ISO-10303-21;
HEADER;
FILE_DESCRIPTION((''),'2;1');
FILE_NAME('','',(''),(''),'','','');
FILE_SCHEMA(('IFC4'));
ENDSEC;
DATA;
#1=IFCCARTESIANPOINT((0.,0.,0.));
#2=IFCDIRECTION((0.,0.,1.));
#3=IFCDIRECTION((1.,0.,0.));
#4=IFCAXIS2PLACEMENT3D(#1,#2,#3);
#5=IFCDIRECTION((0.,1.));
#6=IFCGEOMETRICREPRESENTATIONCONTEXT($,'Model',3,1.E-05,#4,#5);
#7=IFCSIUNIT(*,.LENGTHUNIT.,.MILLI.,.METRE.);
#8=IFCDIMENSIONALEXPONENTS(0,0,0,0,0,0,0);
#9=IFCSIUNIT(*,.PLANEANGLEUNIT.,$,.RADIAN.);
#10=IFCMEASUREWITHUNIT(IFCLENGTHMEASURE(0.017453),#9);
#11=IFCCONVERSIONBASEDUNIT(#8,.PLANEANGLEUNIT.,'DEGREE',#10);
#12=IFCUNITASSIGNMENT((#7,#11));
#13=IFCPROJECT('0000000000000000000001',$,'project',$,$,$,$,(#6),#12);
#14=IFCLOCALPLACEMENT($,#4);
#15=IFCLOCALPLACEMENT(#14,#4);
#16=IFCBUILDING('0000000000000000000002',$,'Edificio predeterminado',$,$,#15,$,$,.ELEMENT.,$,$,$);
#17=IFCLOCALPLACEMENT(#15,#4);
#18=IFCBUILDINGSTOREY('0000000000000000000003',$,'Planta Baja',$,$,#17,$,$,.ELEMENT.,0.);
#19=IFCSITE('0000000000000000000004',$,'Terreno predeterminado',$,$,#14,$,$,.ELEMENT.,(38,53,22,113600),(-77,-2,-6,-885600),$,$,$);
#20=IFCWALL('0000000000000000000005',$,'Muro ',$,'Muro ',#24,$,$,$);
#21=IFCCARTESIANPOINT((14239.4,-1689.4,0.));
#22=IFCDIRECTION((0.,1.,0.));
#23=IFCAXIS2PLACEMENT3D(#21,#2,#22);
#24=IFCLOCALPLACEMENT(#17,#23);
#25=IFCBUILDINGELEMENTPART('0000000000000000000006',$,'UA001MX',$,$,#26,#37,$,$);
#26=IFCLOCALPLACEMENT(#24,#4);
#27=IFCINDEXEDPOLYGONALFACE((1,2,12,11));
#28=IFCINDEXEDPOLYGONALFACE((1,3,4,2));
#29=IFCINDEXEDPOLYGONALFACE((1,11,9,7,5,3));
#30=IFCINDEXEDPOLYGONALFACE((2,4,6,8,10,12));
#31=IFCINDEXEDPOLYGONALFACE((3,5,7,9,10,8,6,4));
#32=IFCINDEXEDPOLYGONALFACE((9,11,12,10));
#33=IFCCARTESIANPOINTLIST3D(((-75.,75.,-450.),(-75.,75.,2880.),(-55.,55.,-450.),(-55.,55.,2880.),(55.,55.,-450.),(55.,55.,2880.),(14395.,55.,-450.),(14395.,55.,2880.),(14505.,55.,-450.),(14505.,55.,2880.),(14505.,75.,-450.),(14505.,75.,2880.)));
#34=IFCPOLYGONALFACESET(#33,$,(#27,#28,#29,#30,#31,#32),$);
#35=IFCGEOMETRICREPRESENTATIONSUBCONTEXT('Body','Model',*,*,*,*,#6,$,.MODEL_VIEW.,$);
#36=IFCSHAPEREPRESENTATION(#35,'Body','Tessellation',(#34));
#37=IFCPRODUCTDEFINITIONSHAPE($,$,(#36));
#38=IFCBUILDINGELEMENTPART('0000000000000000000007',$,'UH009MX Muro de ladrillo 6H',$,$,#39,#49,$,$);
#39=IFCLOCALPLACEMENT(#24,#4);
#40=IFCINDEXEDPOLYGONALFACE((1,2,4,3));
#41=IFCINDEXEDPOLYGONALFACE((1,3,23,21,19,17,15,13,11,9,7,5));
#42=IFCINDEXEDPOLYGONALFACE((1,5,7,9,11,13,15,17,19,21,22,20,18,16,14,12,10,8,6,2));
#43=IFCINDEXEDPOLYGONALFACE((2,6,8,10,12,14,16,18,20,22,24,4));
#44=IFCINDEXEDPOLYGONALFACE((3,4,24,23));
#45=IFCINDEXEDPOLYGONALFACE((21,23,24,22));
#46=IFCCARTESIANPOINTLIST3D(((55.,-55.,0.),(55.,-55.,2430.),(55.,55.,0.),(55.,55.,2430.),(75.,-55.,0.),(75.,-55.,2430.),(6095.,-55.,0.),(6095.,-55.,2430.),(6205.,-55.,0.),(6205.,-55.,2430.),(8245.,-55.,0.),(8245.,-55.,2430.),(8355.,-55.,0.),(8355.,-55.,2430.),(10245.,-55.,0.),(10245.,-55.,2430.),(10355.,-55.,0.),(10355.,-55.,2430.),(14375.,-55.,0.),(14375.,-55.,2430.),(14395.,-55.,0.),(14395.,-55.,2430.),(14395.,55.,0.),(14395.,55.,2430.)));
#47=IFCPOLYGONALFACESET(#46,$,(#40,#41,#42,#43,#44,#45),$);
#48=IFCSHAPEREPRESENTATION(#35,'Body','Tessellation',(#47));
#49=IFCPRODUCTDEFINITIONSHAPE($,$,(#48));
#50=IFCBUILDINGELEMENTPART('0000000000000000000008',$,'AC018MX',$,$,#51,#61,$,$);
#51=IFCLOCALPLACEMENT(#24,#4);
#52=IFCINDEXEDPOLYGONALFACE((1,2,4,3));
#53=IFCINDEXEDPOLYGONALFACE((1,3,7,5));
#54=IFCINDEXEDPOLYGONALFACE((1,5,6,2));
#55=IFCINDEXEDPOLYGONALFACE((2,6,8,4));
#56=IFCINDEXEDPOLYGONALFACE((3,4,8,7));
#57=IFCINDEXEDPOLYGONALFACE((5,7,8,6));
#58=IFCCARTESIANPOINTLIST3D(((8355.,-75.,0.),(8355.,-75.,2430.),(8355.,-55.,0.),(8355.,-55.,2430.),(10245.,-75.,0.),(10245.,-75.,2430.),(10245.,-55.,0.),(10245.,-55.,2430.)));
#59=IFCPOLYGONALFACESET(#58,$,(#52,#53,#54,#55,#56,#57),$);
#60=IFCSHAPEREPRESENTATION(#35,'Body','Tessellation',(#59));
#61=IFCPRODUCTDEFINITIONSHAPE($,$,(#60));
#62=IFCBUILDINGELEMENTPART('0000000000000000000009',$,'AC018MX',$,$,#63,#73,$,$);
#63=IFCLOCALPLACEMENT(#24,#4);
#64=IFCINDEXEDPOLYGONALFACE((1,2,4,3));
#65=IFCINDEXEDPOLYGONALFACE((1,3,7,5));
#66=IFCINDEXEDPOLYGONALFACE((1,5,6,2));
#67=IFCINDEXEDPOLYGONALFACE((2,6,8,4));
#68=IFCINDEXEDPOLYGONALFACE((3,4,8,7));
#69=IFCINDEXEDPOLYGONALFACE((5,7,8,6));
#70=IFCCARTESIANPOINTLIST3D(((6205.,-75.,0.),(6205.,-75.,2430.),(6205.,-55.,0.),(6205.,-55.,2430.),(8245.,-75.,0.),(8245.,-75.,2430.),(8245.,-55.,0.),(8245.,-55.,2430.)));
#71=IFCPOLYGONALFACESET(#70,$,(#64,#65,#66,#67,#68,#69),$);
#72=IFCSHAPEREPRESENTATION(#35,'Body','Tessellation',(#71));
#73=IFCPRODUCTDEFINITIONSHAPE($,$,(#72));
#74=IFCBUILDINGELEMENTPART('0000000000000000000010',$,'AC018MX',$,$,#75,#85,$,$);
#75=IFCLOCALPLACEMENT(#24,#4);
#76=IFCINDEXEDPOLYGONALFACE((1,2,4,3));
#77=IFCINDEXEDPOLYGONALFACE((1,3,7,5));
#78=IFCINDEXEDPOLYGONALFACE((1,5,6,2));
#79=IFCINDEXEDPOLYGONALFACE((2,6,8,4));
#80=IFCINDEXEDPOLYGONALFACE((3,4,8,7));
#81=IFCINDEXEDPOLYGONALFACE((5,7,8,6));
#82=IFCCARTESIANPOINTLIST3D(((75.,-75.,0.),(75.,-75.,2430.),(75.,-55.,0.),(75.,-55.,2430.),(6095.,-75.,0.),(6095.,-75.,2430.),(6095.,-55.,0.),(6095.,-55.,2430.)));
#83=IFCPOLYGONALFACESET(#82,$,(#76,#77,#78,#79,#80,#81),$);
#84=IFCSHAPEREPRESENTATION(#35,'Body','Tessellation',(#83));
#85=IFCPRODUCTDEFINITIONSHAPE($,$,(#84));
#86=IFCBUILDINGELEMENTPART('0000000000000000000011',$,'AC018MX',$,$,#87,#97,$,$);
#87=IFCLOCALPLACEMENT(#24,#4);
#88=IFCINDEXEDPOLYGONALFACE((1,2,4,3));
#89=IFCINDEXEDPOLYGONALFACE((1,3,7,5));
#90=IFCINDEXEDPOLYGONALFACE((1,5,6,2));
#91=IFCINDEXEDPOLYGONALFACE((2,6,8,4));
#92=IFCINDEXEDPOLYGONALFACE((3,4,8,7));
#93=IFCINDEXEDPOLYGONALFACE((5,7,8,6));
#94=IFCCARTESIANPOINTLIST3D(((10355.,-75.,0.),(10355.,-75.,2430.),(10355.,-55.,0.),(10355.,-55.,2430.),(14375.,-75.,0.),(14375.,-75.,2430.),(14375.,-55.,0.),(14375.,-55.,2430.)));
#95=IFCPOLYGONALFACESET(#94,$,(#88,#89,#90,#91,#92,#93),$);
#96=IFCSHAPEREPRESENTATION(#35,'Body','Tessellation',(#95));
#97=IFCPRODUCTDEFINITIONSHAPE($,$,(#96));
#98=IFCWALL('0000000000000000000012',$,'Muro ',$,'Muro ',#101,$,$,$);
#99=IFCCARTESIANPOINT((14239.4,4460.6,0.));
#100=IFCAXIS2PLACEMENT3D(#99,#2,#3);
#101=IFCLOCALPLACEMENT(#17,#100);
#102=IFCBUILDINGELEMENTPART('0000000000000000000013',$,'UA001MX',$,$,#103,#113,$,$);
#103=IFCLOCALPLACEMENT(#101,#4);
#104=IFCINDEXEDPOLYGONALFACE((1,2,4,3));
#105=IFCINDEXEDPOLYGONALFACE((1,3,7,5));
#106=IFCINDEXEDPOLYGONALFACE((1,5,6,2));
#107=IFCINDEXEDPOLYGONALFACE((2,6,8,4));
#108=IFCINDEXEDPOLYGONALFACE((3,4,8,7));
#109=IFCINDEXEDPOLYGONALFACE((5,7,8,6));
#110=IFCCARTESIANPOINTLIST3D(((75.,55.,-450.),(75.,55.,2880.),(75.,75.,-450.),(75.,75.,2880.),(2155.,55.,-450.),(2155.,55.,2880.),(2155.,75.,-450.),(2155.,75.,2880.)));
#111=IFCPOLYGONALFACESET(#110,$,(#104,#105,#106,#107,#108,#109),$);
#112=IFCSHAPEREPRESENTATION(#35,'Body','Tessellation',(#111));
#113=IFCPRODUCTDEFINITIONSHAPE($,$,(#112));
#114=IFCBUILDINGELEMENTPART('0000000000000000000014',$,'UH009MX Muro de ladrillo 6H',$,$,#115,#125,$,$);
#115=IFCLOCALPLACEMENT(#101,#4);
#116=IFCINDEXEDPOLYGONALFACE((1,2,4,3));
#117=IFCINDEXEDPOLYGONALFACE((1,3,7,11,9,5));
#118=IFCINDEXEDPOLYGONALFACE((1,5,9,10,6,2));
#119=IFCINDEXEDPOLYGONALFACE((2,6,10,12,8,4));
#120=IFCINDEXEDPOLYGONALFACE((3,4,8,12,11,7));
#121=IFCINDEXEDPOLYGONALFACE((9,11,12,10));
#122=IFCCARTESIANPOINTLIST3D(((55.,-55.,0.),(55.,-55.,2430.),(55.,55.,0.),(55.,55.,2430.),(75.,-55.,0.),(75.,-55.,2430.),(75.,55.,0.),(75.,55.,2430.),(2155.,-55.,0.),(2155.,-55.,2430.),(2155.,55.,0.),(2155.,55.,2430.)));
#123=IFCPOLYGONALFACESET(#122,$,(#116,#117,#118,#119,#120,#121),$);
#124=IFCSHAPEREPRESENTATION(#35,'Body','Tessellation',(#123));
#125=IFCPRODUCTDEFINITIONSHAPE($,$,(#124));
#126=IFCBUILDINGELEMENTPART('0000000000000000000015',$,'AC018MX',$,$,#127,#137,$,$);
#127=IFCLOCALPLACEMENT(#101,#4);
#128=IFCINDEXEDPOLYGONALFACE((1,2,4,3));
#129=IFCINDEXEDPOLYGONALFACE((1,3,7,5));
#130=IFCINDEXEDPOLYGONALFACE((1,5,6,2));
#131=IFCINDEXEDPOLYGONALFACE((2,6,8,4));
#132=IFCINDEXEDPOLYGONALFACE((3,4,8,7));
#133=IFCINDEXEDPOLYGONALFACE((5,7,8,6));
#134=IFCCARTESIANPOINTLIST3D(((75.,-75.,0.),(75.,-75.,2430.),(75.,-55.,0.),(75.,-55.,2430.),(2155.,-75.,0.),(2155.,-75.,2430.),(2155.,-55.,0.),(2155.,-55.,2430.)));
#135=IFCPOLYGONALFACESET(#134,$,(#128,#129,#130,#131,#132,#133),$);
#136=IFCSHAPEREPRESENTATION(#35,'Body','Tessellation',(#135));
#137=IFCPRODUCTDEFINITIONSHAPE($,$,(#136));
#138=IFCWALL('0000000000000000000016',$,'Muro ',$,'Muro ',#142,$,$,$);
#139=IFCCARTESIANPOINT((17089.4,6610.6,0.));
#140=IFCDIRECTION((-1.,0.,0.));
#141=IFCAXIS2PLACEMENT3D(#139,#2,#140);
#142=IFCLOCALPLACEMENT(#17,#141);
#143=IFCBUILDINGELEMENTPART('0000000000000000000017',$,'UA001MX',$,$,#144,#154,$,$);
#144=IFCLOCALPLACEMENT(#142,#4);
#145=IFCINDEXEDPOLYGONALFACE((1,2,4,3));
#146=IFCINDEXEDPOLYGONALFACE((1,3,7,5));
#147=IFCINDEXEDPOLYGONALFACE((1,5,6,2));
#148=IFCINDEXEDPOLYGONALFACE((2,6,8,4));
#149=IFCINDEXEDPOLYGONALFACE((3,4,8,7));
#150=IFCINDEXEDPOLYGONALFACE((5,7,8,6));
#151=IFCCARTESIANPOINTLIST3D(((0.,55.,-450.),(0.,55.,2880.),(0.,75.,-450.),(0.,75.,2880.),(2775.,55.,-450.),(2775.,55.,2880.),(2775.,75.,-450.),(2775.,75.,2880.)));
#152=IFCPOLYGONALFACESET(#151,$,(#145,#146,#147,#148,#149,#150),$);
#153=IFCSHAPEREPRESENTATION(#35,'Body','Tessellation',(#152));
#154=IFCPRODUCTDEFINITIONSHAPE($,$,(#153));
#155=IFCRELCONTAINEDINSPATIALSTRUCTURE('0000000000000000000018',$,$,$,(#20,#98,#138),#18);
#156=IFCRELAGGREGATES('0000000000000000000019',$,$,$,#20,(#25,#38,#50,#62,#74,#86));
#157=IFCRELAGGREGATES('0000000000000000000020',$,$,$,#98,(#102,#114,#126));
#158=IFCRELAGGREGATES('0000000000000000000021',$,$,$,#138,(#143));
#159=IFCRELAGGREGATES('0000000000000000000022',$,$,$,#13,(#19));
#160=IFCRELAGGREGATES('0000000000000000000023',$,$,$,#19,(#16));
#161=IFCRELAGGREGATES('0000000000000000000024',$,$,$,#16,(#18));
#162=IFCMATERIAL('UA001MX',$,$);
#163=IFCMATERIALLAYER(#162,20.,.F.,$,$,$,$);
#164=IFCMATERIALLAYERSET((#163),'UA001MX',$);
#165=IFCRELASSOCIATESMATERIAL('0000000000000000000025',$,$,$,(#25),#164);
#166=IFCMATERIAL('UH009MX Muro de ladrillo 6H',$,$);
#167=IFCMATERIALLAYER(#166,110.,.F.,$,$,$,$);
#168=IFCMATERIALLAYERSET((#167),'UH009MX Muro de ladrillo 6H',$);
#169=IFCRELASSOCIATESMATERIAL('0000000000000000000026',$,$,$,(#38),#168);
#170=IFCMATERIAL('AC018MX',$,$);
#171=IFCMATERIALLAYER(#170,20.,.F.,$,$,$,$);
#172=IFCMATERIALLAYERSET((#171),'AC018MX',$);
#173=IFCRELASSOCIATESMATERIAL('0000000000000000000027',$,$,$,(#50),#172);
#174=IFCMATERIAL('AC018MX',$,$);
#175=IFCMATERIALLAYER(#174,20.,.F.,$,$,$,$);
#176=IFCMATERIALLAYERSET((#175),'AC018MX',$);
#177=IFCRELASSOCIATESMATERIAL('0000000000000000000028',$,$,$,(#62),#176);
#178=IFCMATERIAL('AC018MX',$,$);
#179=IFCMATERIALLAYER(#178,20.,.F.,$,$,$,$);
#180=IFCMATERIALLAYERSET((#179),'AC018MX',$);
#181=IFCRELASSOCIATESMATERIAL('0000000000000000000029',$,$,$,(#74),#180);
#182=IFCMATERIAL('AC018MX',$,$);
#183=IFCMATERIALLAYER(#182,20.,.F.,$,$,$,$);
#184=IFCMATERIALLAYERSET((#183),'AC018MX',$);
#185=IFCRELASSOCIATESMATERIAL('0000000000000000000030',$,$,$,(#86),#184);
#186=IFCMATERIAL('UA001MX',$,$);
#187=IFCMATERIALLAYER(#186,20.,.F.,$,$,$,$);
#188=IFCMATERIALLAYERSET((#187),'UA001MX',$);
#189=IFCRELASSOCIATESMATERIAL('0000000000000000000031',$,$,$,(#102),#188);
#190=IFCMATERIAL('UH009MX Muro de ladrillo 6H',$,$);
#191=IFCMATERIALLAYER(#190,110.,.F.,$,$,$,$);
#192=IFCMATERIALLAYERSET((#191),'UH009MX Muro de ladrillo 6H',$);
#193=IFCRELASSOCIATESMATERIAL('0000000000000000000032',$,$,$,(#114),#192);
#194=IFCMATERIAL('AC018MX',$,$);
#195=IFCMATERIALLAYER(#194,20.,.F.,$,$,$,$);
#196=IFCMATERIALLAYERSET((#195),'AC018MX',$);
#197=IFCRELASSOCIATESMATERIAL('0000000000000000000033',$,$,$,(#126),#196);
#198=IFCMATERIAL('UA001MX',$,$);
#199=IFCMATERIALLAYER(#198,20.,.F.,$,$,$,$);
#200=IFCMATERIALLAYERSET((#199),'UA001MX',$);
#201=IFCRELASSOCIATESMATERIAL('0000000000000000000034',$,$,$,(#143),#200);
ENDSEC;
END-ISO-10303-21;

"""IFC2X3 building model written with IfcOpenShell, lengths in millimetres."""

from ifc_helpers import new_model, entity, si_unit, converted_unit, direction, frame, origin_with_axes, place, context, subcontext, project, spatial, polyline, outline, extrude, material, layer, layer_set, layer_usage, element, aggregate, save


model = new_model("IFC2X3")

# Units and contexts
model_context = context("Model", 3, precision=1e-05, world=origin_with_axes(), true_north=direction((0.0, 1.0)))
body_context = subcontext(model_context, "Body", "Model", "MODEL_VIEW")
ifc_project = project(units=[si_unit("LENGTHUNIT", "METRE", prefix="MILLI"), converted_unit("PLANEANGLEUNIT", "DEGREE", entity("IfcLengthMeasure", 0.017453), si_unit("PLANEANGLEUNIT", "RADIAN"), dimensions=[0, 0, 0, 0, 0, 0, 0])], contexts=[model_context])

# Site, building, storey
site_placement = place(None, origin_with_axes())
site = spatial("IfcSite", under=ifc_project, at=site_placement, Name="Terreno predeterminado", CompositionType="ELEMENT", RefLatitude=(38, 53, 22, 113600), RefLongitude=(-77, -2, -6, -885600))
building_placement = place(site_placement, origin_with_axes())
building = spatial("IfcBuilding", under=site, at=building_placement, Name="Edificio predeterminado", CompositionType="ELEMENT")
storey_placement = place(building_placement, origin_with_axes())
storey = spatial("IfcBuildingStorey", under=building, at=storey_placement, Name="Planta Baja", CompositionType="ELEMENT", Elevation=0.0)

# Walls, building element parts
wall_1_placement = place(storey_placement, frame((14239.4, -1689.4, 0.0), z_axis=(0.0, 0.0, 1.0), x_axis=(0.0, 1.0, 0.0)))
wall_1 = element("IfcWall", 1, at=wall_1_placement, inside=storey, Name="Muro ", ObjectType="Muro ")
ifc_material_1 = material(Name="UA001MX")
ifc_layer_1 = layer(ifc_material_1, 20.0, ventilated=False)
ifc_layer_set_1 = layer_set([ifc_layer_1], Name="UA001MX")
ifc_layer_usage_1 = layer_usage(ifc_layer_set_1, "AXIS2", "NEGATIVE", -75.0)
building_element_part_1_placement = place(wall_1_placement, origin_with_axes())
building_element_part_1 = element("IfcBuildingElementPart", 2, at=building_element_part_1_placement, material=ifc_layer_usage_1, Name="UA001MX", context=body_context, shape_type="SweptSolid", body=[
    extrude(outline(polyline([(14505.0, 75.0), (14505.0, 55.0), (14395.0, 55.0), (55.0, 55.0), (-55.0, 55.0), (-75.0, 75.0), (14505.0, 75.0)])), frame((0.0, 0.0, -450.0), z_axis=(0.0, 0.0, 1.0), x_axis=(1.0, 0.0, 0.0)), (0.0, 0.0, 1.0), 3330.0),
])
ifc_material_2 = material(Name="UH009MX Muro de ladrillo 6H")
ifc_layer_2 = layer(ifc_material_2, 110.0, ventilated=False)
ifc_layer_set_2 = layer_set([ifc_layer_2], Name="UH009MX Muro de ladrillo 6H")
ifc_layer_usage_2 = layer_usage(ifc_layer_set_2, "AXIS2", "NEGATIVE", -55.0)
building_element_part_2_placement = place(wall_1_placement, origin_with_axes())
building_element_part_2 = element("IfcBuildingElementPart", 3, at=building_element_part_2_placement, material=ifc_layer_usage_2, Name="UH009MX Muro de ladrillo 6H", context=body_context, shape_type="SweptSolid", body=[
    extrude(outline(polyline([(14395.0, 55.0), (14395.0, -55.0), (14375.0, -55.0), (10355.0, -55.0), (10245.0, -55.0), (8355.0, -55.0), (8245.0, -55.0), (6205.0, -55.0), (6095.0, -55.0), (75.0, -55.0), (55.0, -55.0), (55.0, 55.0), (14395.0, 55.0)])), origin_with_axes(), (0.0, 0.0, 1.0), 2430.0),
])
ifc_material_3 = material(Name="AC018MX")
ifc_layer_3 = layer(ifc_material_3, 20.0, ventilated=False)
ifc_layer_set_3 = layer_set([ifc_layer_3], Name="AC018MX")
ifc_layer_usage_3 = layer_usage(ifc_layer_set_3, "AXIS2", "NEGATIVE", 55.0)
building_element_part_3_placement = place(wall_1_placement, origin_with_axes())
building_element_part_3 = element("IfcBuildingElementPart", 4, at=building_element_part_3_placement, material=ifc_layer_usage_3, Name="AC018MX", context=body_context, shape_type="SweptSolid", body=[
    extrude(outline(polyline([(8355.0, -55.0), (10245.0, -55.0), (10245.0, -75.0), (8355.0, -75.0), (8355.0, -55.0)])), origin_with_axes(), (0.0, 0.0, 1.0), 2430.0),
])
ifc_material_4 = material(Name="AC018MX")
ifc_layer_4 = layer(ifc_material_4, 20.0, ventilated=False)
ifc_layer_set_4 = layer_set([ifc_layer_4], Name="AC018MX")
ifc_layer_usage_4 = layer_usage(ifc_layer_set_4, "AXIS2", "NEGATIVE", 55.0)
building_element_part_4_placement = place(wall_1_placement, origin_with_axes())
building_element_part_4 = element("IfcBuildingElementPart", 5, at=building_element_part_4_placement, material=ifc_layer_usage_4, Name="AC018MX", context=body_context, shape_type="SweptSolid", body=[
    extrude(outline(polyline([(8245.0, -55.0), (8245.0, -75.0), (6205.0, -75.0), (6205.0, -55.0), (8245.0, -55.0)])), origin_with_axes(), (0.0, 0.0, 1.0), 2430.0),
])
ifc_material_5 = material(Name="AC018MX")
ifc_layer_5 = layer(ifc_material_5, 20.0, ventilated=False)
ifc_layer_set_5 = layer_set([ifc_layer_5], Name="AC018MX")
ifc_layer_usage_5 = layer_usage(ifc_layer_set_5, "AXIS2", "NEGATIVE", 55.0)
building_element_part_5_placement = place(wall_1_placement, origin_with_axes())
building_element_part_5 = element("IfcBuildingElementPart", 6, at=building_element_part_5_placement, material=ifc_layer_usage_5, Name="AC018MX", context=body_context, shape_type="SweptSolid", body=[
    extrude(outline(polyline([(6095.0, -55.0), (6095.0, -75.0), (75.0, -75.0), (75.0, -55.0), (6095.0, -55.0)])), origin_with_axes(), (0.0, 0.0, 1.0), 2430.0),
])
ifc_material_6 = material(Name="AC018MX")
ifc_layer_6 = layer(ifc_material_6, 20.0, ventilated=False)
ifc_layer_set_6 = layer_set([ifc_layer_6], Name="AC018MX")
ifc_layer_usage_6 = layer_usage(ifc_layer_set_6, "AXIS2", "NEGATIVE", 55.0)
building_element_part_6_placement = place(wall_1_placement, origin_with_axes())
building_element_part_6 = element("IfcBuildingElementPart", 7, at=building_element_part_6_placement, material=ifc_layer_usage_6, Name="AC018MX", context=body_context, shape_type="SweptSolid", body=[
    extrude(outline(polyline([(14375.0, -55.0), (14375.0, -75.0), (10355.0, -75.0), (10355.0, -55.0), (14375.0, -55.0)])), origin_with_axes(), (0.0, 0.0, 1.0), 2430.0),
])
aggregate(wall_1, [building_element_part_1, building_element_part_2, building_element_part_3, building_element_part_4, building_element_part_5, building_element_part_6])
wall_2_placement = place(storey_placement, frame((14239.4, 4460.6, 0.0), z_axis=(0.0, 0.0, 1.0), x_axis=(1.0, 0.0, 0.0)))
wall_2 = element("IfcWall", 8, at=wall_2_placement, inside=storey, Name="Muro ", ObjectType="Muro ")
ifc_material_7 = material(Name="UA001MX")
ifc_layer_7 = layer(ifc_material_7, 20.0, ventilated=False)
ifc_layer_set_7 = layer_set([ifc_layer_7], Name="UA001MX")
ifc_layer_usage_7 = layer_usage(ifc_layer_set_7, "AXIS2", "NEGATIVE", -75.0)
building_element_part_7_placement = place(wall_2_placement, origin_with_axes())
building_element_part_7 = element("IfcBuildingElementPart", 9, at=building_element_part_7_placement, material=ifc_layer_usage_7, Name="UA001MX", context=body_context, shape_type="SweptSolid", body=[
    extrude(outline(polyline([(2155.0, 75.0), (2155.0, 55.0), (75.0, 55.0), (75.0, 75.0), (2155.0, 75.0)])), frame((0.0, 0.0, -450.0), z_axis=(0.0, 0.0, 1.0), x_axis=(1.0, 0.0, 0.0)), (0.0, 0.0, 1.0), 3330.0),
])
ifc_material_8 = material(Name="UH009MX Muro de ladrillo 6H")
ifc_layer_8 = layer(ifc_material_8, 110.0, ventilated=False)
ifc_layer_set_8 = layer_set([ifc_layer_8], Name="UH009MX Muro de ladrillo 6H")
ifc_layer_usage_8 = layer_usage(ifc_layer_set_8, "AXIS2", "NEGATIVE", -55.0)
building_element_part_8_placement = place(wall_2_placement, origin_with_axes())
building_element_part_8 = element("IfcBuildingElementPart", 10, at=building_element_part_8_placement, material=ifc_layer_usage_8, Name="UH009MX Muro de ladrillo 6H", context=body_context, shape_type="SweptSolid", body=[
    extrude(outline(polyline([(2155.0, 55.0), (2155.0, -55.0), (75.0, -55.0), (55.0, -55.0), (55.0, 55.0), (75.0, 55.0), (2155.0, 55.0)])), origin_with_axes(), (0.0, 0.0, 1.0), 2430.0),
])
ifc_material_9 = material(Name="AC018MX")
ifc_layer_9 = layer(ifc_material_9, 20.0, ventilated=False)
ifc_layer_set_9 = layer_set([ifc_layer_9], Name="AC018MX")
ifc_layer_usage_9 = layer_usage(ifc_layer_set_9, "AXIS2", "NEGATIVE", 55.0)
building_element_part_9_placement = place(wall_2_placement, origin_with_axes())
building_element_part_9 = element("IfcBuildingElementPart", 11, at=building_element_part_9_placement, material=ifc_layer_usage_9, Name="AC018MX", context=body_context, shape_type="SweptSolid", body=[
    extrude(outline(polyline([(2155.0, -55.0), (2155.0, -75.0), (75.0, -75.0), (75.0, -55.0), (2155.0, -55.0)])), origin_with_axes(), (0.0, 0.0, 1.0), 2430.0),
])
aggregate(wall_2, [building_element_part_7, building_element_part_8, building_element_part_9])

# Wall, building element part
wall_3_placement = place(storey_placement, frame((17089.4, 6610.6, 0.0), z_axis=(0.0, 0.0, 1.0), x_axis=(-1.0, 0.0, 0.0)))
wall_3 = element("IfcWall", 12, at=wall_3_placement, inside=storey, Name="Muro ", ObjectType="Muro ")
ifc_material_10 = material(Name="UA001MX")
ifc_layer_10 = layer(ifc_material_10, 20.0, ventilated=False)
ifc_layer_set_10 = layer_set([ifc_layer_10], Name="UA001MX")
ifc_layer_usage_10 = layer_usage(ifc_layer_set_10, "AXIS2", "NEGATIVE", -75.0)
building_element_part_10_placement = place(wall_3_placement, origin_with_axes())
building_element_part_10 = element("IfcBuildingElementPart", 13, at=building_element_part_10_placement, material=ifc_layer_usage_10, Name="UA001MX", context=body_context, shape_type="SweptSolid", body=[
    extrude(outline(polyline([(0.0, 75.0), (2775.0, 75.0), (2775.0, 55.0), (0.0, 55.0), (0.0, 75.0)])), frame((0.0, 0.0, -450.0), z_axis=(0.0, 0.0, 1.0), x_axis=(1.0, 0.0, 0.0)), (0.0, 0.0, 1.0), 3330.0),
])
aggregate(wall_3, [building_element_part_10])

save(model, "model.ifc")
